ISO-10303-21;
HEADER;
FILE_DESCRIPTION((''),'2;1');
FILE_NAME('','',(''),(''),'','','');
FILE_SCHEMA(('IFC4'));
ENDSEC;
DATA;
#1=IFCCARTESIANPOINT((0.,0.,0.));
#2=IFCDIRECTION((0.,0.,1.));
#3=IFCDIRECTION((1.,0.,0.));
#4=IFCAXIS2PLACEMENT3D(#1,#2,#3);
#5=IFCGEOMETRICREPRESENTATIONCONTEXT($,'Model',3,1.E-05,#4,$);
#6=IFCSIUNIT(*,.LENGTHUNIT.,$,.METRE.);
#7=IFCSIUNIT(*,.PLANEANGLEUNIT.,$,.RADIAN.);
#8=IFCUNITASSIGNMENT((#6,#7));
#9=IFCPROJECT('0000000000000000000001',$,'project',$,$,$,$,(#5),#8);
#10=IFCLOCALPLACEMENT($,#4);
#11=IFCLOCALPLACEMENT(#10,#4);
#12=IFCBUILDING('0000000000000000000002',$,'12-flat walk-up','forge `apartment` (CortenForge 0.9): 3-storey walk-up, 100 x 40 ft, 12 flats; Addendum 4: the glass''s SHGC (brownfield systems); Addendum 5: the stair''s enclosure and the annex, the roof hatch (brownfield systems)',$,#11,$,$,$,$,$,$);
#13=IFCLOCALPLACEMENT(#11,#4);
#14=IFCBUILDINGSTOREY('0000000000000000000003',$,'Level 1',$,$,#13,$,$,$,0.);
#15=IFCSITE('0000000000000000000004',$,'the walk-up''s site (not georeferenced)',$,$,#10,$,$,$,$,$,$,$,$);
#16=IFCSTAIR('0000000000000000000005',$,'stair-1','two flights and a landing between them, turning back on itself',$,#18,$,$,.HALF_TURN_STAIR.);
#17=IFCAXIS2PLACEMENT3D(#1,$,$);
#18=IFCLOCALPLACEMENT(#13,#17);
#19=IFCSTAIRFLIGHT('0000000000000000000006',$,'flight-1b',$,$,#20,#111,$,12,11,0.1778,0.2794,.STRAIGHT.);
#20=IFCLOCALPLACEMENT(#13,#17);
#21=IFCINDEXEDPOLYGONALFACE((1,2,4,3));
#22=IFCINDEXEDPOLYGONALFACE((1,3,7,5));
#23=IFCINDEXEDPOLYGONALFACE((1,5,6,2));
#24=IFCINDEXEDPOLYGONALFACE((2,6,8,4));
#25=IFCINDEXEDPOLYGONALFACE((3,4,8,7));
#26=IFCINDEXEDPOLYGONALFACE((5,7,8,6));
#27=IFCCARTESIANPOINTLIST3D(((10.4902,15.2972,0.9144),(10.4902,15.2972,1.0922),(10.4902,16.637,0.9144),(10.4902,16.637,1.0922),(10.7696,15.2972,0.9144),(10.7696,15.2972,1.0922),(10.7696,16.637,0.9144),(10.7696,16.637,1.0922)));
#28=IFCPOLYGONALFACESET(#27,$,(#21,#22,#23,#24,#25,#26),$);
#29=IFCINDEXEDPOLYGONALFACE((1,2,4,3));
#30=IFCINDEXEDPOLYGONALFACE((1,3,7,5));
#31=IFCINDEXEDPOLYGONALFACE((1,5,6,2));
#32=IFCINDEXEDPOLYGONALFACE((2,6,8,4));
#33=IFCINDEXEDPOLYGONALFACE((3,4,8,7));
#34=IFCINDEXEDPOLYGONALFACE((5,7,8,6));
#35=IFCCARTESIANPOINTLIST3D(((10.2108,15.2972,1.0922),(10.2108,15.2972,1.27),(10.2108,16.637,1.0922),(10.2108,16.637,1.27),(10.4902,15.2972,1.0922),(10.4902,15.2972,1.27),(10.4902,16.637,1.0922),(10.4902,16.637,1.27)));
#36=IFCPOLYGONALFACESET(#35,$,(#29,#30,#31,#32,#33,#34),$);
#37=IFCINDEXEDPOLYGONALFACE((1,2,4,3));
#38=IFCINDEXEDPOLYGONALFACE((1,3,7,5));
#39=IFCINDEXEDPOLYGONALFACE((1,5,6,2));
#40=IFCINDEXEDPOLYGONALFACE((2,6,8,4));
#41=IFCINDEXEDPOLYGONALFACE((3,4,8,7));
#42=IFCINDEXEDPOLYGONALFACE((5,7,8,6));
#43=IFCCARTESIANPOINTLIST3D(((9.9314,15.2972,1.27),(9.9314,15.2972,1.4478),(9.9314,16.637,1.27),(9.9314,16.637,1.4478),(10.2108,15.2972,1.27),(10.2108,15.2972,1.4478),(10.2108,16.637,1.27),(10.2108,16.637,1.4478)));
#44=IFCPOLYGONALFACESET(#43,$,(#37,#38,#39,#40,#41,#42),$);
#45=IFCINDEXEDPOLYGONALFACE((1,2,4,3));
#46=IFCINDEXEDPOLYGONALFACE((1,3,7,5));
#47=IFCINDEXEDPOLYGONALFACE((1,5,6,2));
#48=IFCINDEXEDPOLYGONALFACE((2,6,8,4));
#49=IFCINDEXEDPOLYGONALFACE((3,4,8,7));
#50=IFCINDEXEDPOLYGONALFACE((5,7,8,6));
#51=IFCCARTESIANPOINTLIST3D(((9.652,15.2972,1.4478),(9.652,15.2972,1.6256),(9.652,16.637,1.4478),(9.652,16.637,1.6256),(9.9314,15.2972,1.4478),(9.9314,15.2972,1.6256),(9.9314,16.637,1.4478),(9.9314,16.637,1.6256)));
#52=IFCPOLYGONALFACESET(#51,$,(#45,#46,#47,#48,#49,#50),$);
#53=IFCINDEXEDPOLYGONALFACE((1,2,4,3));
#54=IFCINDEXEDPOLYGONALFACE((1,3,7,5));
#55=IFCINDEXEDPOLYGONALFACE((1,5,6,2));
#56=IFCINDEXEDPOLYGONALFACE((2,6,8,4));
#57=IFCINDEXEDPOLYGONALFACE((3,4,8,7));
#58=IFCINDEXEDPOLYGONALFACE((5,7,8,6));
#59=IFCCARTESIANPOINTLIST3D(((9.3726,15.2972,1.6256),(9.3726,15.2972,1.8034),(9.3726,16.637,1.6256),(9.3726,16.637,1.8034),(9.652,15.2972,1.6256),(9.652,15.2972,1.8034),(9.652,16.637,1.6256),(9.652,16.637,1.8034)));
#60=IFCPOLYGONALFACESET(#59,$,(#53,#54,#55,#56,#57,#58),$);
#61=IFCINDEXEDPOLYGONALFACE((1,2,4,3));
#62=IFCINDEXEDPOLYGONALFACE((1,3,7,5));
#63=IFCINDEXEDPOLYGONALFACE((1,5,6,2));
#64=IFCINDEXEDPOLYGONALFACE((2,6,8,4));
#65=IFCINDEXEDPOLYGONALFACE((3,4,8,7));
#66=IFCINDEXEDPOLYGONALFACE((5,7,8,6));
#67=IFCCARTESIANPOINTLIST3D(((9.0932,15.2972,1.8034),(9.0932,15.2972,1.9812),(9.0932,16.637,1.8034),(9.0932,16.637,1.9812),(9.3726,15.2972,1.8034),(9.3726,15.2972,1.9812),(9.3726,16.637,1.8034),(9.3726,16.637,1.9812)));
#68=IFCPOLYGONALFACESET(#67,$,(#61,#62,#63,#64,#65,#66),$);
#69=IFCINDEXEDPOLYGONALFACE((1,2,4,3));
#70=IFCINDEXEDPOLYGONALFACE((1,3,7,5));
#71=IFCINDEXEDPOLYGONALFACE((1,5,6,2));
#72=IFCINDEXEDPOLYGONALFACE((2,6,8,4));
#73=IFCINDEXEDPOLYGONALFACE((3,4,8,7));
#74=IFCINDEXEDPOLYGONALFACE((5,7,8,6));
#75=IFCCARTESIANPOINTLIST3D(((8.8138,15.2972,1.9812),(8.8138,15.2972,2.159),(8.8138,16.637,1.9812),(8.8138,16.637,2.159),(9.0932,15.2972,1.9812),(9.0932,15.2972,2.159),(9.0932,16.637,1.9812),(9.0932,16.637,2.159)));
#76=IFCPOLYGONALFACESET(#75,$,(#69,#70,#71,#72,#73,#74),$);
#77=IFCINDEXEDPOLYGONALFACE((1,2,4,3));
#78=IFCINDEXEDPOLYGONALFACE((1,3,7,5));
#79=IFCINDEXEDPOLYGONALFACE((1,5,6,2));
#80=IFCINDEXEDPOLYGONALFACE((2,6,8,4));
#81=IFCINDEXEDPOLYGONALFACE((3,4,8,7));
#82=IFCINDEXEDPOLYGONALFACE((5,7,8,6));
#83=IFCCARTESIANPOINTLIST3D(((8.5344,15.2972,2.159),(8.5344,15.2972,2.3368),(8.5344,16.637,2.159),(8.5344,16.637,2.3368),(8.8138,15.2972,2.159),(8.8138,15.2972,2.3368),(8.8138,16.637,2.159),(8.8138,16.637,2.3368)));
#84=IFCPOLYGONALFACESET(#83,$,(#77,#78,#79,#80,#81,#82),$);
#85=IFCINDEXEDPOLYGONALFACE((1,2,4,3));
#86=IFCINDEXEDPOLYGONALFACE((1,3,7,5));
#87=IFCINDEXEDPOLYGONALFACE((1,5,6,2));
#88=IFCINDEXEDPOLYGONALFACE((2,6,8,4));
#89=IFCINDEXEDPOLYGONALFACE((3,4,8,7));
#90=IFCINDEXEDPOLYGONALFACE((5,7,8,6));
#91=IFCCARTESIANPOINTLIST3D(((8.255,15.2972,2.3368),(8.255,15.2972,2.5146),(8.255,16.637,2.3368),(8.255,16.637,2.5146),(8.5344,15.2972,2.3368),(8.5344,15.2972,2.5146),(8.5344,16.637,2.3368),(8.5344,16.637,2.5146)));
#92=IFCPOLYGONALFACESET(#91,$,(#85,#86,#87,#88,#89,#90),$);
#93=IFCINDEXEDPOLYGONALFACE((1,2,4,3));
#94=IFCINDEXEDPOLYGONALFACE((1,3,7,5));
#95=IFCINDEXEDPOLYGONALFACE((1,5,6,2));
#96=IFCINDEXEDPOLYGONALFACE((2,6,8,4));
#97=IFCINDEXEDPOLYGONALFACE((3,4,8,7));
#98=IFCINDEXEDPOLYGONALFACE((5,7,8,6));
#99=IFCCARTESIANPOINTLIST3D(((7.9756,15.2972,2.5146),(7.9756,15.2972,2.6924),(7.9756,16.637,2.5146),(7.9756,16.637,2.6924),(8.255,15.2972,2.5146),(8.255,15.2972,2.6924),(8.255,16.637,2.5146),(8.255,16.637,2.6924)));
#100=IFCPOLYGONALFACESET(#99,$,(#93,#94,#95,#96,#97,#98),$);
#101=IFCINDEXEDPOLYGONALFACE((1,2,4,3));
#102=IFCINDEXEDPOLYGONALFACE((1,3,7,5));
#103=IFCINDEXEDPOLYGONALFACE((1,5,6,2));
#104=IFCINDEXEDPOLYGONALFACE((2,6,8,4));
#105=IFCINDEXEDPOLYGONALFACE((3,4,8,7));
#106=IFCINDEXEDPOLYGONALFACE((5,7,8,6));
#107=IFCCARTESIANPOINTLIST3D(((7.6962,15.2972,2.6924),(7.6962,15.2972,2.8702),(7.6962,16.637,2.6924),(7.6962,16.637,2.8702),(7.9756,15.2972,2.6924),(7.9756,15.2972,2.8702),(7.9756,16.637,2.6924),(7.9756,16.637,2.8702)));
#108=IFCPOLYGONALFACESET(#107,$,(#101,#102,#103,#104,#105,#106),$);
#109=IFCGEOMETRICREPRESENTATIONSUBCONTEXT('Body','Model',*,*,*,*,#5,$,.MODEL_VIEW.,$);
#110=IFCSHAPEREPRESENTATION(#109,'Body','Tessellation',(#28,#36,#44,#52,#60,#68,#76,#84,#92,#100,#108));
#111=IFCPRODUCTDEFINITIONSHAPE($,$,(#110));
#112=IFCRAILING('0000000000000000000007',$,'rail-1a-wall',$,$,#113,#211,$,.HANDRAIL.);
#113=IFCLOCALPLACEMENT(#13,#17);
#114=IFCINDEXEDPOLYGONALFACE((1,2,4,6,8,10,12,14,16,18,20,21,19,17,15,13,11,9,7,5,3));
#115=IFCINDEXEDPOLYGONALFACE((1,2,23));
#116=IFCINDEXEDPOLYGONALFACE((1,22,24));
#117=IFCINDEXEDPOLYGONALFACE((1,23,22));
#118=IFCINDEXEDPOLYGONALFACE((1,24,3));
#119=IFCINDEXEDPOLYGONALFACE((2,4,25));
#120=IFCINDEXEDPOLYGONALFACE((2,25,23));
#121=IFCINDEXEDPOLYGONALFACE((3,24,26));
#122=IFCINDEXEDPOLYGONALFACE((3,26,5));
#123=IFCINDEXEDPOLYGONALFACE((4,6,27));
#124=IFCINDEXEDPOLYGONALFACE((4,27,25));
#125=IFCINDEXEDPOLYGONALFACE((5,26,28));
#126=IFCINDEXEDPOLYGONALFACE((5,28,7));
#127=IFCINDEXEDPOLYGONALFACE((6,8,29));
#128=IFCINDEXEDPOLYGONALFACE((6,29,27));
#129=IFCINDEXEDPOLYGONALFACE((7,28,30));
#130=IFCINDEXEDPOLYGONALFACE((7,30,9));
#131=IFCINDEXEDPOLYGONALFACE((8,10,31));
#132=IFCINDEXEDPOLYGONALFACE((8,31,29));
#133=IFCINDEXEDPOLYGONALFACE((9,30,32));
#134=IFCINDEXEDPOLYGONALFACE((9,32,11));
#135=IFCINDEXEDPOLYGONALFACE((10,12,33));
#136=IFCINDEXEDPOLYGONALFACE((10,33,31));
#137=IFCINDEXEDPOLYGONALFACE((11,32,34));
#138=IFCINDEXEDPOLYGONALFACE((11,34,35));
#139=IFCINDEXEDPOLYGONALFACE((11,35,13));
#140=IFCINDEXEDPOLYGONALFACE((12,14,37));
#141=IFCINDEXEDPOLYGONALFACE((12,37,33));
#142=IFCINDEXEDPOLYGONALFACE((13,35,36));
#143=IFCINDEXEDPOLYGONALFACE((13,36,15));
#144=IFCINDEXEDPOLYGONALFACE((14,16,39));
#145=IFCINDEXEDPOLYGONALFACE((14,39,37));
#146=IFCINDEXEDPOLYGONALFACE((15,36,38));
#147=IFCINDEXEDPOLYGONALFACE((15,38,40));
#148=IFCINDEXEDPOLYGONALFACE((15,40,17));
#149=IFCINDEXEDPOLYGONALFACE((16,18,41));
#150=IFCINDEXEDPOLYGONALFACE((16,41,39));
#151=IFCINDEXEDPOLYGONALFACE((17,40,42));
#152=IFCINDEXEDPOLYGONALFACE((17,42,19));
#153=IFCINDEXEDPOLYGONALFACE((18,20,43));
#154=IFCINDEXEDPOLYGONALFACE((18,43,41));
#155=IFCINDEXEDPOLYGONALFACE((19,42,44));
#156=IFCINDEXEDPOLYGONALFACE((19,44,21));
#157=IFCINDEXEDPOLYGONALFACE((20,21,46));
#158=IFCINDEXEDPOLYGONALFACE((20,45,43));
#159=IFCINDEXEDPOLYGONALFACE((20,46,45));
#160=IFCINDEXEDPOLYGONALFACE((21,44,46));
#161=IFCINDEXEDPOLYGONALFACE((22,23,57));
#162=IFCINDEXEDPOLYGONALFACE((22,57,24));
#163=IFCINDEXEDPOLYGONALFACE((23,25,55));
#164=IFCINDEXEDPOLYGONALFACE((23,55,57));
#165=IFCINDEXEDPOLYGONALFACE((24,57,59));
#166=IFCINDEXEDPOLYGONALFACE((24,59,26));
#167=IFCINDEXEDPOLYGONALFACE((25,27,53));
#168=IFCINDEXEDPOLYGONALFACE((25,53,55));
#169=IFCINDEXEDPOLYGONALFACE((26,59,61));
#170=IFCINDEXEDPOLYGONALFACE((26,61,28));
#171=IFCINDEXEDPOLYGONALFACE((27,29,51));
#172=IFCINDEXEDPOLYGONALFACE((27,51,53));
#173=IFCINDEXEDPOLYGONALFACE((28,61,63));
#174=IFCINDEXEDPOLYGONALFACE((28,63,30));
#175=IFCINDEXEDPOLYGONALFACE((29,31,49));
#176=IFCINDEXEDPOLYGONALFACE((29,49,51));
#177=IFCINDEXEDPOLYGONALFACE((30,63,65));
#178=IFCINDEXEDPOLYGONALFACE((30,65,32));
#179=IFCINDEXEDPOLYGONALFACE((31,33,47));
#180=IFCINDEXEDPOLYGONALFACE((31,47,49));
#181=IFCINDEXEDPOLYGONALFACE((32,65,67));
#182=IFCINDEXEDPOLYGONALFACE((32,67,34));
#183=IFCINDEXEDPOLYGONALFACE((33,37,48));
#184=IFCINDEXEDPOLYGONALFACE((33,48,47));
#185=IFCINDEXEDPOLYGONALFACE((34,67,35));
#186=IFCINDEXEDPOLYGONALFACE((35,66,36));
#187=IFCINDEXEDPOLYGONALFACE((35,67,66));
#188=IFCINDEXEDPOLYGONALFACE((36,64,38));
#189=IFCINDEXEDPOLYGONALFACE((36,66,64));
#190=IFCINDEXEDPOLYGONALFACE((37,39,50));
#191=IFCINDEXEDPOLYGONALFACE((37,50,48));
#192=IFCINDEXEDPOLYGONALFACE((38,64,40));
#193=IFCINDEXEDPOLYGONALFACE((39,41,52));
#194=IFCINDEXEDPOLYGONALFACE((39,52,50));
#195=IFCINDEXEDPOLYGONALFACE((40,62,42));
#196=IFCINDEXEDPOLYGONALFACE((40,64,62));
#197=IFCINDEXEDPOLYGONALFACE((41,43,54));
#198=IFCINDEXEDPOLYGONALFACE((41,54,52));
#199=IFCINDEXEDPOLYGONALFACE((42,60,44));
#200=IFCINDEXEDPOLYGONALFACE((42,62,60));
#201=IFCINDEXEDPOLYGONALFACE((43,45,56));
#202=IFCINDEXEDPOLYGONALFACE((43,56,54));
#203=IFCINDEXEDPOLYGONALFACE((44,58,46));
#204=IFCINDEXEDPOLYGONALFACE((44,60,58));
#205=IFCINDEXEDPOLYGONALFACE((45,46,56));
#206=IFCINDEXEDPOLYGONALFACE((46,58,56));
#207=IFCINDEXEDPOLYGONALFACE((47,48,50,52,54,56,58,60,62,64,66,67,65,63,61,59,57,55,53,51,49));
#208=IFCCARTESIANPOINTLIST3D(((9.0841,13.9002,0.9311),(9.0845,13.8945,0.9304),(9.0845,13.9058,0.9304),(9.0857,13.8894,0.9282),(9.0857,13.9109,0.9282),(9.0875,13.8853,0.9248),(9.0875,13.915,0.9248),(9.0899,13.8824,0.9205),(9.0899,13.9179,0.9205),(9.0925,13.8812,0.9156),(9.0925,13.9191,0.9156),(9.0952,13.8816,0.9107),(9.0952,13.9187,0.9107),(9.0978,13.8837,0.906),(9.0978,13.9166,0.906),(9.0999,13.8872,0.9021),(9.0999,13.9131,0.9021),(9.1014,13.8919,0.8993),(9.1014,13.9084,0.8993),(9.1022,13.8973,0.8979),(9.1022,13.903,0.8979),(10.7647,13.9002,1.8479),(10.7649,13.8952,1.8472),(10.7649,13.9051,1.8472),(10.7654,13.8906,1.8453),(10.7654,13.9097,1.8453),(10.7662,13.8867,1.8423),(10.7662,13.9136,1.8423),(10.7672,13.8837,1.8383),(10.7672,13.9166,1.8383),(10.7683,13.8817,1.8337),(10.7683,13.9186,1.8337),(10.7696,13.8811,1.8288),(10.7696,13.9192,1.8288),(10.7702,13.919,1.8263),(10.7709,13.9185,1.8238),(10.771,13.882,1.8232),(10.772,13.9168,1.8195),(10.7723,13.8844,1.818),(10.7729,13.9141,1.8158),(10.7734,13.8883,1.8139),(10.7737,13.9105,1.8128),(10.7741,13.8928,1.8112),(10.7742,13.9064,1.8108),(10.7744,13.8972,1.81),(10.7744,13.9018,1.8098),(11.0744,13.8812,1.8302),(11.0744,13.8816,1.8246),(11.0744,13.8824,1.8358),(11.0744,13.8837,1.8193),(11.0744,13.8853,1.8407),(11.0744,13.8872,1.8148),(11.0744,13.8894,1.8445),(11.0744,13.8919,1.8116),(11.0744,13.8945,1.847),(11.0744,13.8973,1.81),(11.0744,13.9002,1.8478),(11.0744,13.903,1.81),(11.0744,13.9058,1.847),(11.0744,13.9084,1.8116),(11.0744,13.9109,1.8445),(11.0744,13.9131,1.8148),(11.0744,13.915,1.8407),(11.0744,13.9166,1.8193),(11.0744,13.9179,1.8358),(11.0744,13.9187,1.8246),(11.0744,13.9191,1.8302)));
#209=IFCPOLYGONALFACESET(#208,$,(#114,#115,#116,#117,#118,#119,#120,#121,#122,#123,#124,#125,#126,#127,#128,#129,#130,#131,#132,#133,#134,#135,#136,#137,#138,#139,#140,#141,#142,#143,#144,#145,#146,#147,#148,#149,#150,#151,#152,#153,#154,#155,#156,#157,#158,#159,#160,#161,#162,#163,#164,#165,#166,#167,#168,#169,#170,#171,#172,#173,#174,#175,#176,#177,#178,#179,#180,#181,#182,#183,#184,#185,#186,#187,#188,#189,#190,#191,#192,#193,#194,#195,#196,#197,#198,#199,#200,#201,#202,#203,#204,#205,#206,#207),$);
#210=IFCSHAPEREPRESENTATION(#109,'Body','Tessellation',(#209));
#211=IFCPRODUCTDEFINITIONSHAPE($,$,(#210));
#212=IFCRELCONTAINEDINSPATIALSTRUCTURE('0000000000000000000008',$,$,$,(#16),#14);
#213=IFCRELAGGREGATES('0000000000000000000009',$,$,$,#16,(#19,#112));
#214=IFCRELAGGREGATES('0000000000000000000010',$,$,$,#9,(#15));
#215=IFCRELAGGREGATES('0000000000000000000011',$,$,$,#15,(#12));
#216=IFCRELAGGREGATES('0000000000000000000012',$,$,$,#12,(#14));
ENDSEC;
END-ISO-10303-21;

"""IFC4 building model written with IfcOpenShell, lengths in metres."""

from ifc_helpers import new_model, entity, si_unit, frame, frame_2d, origin_with_axes, place, context, subcontext, project, spatial, rectangle, extrude, element, aggregate, save


model = new_model("IFC4")

# Units and contexts
model_context = context("Model", 3, precision=1e-05, world=origin_with_axes())
body_context = subcontext(model_context, "Body", "Model", "MODEL_VIEW")
ifc_project = project(units=[si_unit("LENGTHUNIT", "METRE"), si_unit("PLANEANGLEUNIT", "RADIAN")], contexts=[model_context])

# Site, building, storey
site_placement = place(None, origin_with_axes())
site = spatial("IfcSite", under=ifc_project, at=site_placement, Name="the walk-up's site (not georeferenced)")
building_placement = place(site_placement, origin_with_axes())
building = spatial("IfcBuilding", under=site, at=building_placement, Name="12-flat walk-up", Description="forge `apartment` (CortenForge 0.9): 3-storey walk-up, 100 x 40 ft, 12 flats; Addendum 4: the glass's SHGC (brownfield systems); Addendum 5: the stair's enclosure and the annex, the roof hatch (brownfield systems)")
storey_placement = place(building_placement, origin_with_axes())
storey = spatial("IfcBuildingStorey", under=building, at=storey_placement, Name="Level 1", Elevation=0.0)

# Stair, stair flight, railing
stair_placement = place(storey_placement, origin_with_axes())
stair = element("IfcStair", 1, at=stair_placement, inside=storey, Name="stair-1", Description="two flights and a landing between them, turning back on itself", PredefinedType="HALF_TURN_STAIR")
stair_flight_1_placement = place(stair_placement, frame((7.6962, 15.2972, 0.9144), z_axis=(0.0, 0.0, 1.0), x_axis=(1.0, 0.0, 0.0)))
stair_flight_1 = element("IfcStairFlight", 2, at=stair_flight_1_placement, Name="flight-1b", NumberOfRisers=12, NumberOfTreads=11, PredefinedType="STRAIGHT", RiserHeight=0.1778, TreadLength=0.2794, context=body_context, shape_type="SweptSolid", body=[
    extrude(rectangle(XDim=0.2794, YDim=1.3399, at=frame_2d((0.1397, 0.6699))), frame((2.794, 0.0, 0.0)), (0.0, 0.0, 1.0), 0.1778),
    extrude(rectangle(XDim=0.2794, YDim=1.3399, at=frame_2d((0.1397, 0.6699))), frame((2.5146, 0.0, 0.1778)), (0.0, 0.0, 1.0), 0.1778),
    extrude(rectangle(XDim=0.2794, YDim=1.3399, at=frame_2d((0.1397, 0.6699))), frame((2.2352, 0.0, 0.3556)), (0.0, 0.0, 1.0), 0.1778),
    extrude(rectangle(XDim=0.2794, YDim=1.3399, at=frame_2d((0.1397, 0.6699))), frame((1.9558, 0.0, 0.5334)), (0.0, 0.0, 1.0), 0.1778),
    extrude(rectangle(XDim=0.2794, YDim=1.3399, at=frame_2d((0.1397, 0.6699))), frame((1.6764, 0.0, 0.7112)), (0.0, 0.0, 1.0), 0.1778),
    extrude(rectangle(XDim=0.2794, YDim=1.3399, at=frame_2d((0.1397, 0.6699))), frame((1.397, 0.0, 0.889)), (0.0, 0.0, 1.0), 0.1778),
    extrude(rectangle(XDim=0.2794, YDim=1.3399, at=frame_2d((0.1397, 0.6699))), frame((1.1176, 0.0, 1.0668)), (0.0, 0.0, 1.0), 0.1778),
    extrude(rectangle(XDim=0.2794, YDim=1.3399, at=frame_2d((0.1397, 0.6699))), frame((0.8382, 0.0, 1.2446)), (0.0, 0.0, 1.0), 0.1778),
    extrude(rectangle(XDim=0.2794, YDim=1.3399, at=frame_2d((0.1397, 0.6699))), frame((0.5588, 0.0, 1.4224)), (0.0, 0.0, 1.0), 0.1778),
    extrude(rectangle(XDim=0.2794, YDim=1.3399, at=frame_2d((0.1397, 0.6699))), frame((0.2794, 0.0, 1.6002)), (0.0, 0.0, 1.0), 0.1778),
    extrude(rectangle(XDim=0.2794, YDim=1.3399, at=frame_2d((0.1397, 0.6699))), frame((0.0, 0.0, 1.778)), (0.0, 0.0, 1.0), 0.1778),
])
railing_1_placement = place(stair_placement, frame((9.0932, 13.9002, 0.9144), z_axis=(0.0, 0.0, 1.0), x_axis=(1.0, 0.0, 0.0)))
railing_1 = element("IfcRailing", 3, at=railing_1_placement, Name="rail-1a-wall", PredefinedType="HANDRAIL", context=body_context, shape_type="AdvancedSweptSolid", body=[
    entity("IfcSweptDiskSolid", entity("IfcPolyline", [entity("IfcCartesianPoint", [0.0, 0.0, 0.0]), entity("IfcCartesianPoint", [1.6764, 0.0, 0.9144]), entity("IfcCartesianPoint", [1.9812, 0.0, 0.9144])]), 0.0191),
])
aggregate(stair, [stair_flight_1, railing_1])

save(model, "model.ifc")
